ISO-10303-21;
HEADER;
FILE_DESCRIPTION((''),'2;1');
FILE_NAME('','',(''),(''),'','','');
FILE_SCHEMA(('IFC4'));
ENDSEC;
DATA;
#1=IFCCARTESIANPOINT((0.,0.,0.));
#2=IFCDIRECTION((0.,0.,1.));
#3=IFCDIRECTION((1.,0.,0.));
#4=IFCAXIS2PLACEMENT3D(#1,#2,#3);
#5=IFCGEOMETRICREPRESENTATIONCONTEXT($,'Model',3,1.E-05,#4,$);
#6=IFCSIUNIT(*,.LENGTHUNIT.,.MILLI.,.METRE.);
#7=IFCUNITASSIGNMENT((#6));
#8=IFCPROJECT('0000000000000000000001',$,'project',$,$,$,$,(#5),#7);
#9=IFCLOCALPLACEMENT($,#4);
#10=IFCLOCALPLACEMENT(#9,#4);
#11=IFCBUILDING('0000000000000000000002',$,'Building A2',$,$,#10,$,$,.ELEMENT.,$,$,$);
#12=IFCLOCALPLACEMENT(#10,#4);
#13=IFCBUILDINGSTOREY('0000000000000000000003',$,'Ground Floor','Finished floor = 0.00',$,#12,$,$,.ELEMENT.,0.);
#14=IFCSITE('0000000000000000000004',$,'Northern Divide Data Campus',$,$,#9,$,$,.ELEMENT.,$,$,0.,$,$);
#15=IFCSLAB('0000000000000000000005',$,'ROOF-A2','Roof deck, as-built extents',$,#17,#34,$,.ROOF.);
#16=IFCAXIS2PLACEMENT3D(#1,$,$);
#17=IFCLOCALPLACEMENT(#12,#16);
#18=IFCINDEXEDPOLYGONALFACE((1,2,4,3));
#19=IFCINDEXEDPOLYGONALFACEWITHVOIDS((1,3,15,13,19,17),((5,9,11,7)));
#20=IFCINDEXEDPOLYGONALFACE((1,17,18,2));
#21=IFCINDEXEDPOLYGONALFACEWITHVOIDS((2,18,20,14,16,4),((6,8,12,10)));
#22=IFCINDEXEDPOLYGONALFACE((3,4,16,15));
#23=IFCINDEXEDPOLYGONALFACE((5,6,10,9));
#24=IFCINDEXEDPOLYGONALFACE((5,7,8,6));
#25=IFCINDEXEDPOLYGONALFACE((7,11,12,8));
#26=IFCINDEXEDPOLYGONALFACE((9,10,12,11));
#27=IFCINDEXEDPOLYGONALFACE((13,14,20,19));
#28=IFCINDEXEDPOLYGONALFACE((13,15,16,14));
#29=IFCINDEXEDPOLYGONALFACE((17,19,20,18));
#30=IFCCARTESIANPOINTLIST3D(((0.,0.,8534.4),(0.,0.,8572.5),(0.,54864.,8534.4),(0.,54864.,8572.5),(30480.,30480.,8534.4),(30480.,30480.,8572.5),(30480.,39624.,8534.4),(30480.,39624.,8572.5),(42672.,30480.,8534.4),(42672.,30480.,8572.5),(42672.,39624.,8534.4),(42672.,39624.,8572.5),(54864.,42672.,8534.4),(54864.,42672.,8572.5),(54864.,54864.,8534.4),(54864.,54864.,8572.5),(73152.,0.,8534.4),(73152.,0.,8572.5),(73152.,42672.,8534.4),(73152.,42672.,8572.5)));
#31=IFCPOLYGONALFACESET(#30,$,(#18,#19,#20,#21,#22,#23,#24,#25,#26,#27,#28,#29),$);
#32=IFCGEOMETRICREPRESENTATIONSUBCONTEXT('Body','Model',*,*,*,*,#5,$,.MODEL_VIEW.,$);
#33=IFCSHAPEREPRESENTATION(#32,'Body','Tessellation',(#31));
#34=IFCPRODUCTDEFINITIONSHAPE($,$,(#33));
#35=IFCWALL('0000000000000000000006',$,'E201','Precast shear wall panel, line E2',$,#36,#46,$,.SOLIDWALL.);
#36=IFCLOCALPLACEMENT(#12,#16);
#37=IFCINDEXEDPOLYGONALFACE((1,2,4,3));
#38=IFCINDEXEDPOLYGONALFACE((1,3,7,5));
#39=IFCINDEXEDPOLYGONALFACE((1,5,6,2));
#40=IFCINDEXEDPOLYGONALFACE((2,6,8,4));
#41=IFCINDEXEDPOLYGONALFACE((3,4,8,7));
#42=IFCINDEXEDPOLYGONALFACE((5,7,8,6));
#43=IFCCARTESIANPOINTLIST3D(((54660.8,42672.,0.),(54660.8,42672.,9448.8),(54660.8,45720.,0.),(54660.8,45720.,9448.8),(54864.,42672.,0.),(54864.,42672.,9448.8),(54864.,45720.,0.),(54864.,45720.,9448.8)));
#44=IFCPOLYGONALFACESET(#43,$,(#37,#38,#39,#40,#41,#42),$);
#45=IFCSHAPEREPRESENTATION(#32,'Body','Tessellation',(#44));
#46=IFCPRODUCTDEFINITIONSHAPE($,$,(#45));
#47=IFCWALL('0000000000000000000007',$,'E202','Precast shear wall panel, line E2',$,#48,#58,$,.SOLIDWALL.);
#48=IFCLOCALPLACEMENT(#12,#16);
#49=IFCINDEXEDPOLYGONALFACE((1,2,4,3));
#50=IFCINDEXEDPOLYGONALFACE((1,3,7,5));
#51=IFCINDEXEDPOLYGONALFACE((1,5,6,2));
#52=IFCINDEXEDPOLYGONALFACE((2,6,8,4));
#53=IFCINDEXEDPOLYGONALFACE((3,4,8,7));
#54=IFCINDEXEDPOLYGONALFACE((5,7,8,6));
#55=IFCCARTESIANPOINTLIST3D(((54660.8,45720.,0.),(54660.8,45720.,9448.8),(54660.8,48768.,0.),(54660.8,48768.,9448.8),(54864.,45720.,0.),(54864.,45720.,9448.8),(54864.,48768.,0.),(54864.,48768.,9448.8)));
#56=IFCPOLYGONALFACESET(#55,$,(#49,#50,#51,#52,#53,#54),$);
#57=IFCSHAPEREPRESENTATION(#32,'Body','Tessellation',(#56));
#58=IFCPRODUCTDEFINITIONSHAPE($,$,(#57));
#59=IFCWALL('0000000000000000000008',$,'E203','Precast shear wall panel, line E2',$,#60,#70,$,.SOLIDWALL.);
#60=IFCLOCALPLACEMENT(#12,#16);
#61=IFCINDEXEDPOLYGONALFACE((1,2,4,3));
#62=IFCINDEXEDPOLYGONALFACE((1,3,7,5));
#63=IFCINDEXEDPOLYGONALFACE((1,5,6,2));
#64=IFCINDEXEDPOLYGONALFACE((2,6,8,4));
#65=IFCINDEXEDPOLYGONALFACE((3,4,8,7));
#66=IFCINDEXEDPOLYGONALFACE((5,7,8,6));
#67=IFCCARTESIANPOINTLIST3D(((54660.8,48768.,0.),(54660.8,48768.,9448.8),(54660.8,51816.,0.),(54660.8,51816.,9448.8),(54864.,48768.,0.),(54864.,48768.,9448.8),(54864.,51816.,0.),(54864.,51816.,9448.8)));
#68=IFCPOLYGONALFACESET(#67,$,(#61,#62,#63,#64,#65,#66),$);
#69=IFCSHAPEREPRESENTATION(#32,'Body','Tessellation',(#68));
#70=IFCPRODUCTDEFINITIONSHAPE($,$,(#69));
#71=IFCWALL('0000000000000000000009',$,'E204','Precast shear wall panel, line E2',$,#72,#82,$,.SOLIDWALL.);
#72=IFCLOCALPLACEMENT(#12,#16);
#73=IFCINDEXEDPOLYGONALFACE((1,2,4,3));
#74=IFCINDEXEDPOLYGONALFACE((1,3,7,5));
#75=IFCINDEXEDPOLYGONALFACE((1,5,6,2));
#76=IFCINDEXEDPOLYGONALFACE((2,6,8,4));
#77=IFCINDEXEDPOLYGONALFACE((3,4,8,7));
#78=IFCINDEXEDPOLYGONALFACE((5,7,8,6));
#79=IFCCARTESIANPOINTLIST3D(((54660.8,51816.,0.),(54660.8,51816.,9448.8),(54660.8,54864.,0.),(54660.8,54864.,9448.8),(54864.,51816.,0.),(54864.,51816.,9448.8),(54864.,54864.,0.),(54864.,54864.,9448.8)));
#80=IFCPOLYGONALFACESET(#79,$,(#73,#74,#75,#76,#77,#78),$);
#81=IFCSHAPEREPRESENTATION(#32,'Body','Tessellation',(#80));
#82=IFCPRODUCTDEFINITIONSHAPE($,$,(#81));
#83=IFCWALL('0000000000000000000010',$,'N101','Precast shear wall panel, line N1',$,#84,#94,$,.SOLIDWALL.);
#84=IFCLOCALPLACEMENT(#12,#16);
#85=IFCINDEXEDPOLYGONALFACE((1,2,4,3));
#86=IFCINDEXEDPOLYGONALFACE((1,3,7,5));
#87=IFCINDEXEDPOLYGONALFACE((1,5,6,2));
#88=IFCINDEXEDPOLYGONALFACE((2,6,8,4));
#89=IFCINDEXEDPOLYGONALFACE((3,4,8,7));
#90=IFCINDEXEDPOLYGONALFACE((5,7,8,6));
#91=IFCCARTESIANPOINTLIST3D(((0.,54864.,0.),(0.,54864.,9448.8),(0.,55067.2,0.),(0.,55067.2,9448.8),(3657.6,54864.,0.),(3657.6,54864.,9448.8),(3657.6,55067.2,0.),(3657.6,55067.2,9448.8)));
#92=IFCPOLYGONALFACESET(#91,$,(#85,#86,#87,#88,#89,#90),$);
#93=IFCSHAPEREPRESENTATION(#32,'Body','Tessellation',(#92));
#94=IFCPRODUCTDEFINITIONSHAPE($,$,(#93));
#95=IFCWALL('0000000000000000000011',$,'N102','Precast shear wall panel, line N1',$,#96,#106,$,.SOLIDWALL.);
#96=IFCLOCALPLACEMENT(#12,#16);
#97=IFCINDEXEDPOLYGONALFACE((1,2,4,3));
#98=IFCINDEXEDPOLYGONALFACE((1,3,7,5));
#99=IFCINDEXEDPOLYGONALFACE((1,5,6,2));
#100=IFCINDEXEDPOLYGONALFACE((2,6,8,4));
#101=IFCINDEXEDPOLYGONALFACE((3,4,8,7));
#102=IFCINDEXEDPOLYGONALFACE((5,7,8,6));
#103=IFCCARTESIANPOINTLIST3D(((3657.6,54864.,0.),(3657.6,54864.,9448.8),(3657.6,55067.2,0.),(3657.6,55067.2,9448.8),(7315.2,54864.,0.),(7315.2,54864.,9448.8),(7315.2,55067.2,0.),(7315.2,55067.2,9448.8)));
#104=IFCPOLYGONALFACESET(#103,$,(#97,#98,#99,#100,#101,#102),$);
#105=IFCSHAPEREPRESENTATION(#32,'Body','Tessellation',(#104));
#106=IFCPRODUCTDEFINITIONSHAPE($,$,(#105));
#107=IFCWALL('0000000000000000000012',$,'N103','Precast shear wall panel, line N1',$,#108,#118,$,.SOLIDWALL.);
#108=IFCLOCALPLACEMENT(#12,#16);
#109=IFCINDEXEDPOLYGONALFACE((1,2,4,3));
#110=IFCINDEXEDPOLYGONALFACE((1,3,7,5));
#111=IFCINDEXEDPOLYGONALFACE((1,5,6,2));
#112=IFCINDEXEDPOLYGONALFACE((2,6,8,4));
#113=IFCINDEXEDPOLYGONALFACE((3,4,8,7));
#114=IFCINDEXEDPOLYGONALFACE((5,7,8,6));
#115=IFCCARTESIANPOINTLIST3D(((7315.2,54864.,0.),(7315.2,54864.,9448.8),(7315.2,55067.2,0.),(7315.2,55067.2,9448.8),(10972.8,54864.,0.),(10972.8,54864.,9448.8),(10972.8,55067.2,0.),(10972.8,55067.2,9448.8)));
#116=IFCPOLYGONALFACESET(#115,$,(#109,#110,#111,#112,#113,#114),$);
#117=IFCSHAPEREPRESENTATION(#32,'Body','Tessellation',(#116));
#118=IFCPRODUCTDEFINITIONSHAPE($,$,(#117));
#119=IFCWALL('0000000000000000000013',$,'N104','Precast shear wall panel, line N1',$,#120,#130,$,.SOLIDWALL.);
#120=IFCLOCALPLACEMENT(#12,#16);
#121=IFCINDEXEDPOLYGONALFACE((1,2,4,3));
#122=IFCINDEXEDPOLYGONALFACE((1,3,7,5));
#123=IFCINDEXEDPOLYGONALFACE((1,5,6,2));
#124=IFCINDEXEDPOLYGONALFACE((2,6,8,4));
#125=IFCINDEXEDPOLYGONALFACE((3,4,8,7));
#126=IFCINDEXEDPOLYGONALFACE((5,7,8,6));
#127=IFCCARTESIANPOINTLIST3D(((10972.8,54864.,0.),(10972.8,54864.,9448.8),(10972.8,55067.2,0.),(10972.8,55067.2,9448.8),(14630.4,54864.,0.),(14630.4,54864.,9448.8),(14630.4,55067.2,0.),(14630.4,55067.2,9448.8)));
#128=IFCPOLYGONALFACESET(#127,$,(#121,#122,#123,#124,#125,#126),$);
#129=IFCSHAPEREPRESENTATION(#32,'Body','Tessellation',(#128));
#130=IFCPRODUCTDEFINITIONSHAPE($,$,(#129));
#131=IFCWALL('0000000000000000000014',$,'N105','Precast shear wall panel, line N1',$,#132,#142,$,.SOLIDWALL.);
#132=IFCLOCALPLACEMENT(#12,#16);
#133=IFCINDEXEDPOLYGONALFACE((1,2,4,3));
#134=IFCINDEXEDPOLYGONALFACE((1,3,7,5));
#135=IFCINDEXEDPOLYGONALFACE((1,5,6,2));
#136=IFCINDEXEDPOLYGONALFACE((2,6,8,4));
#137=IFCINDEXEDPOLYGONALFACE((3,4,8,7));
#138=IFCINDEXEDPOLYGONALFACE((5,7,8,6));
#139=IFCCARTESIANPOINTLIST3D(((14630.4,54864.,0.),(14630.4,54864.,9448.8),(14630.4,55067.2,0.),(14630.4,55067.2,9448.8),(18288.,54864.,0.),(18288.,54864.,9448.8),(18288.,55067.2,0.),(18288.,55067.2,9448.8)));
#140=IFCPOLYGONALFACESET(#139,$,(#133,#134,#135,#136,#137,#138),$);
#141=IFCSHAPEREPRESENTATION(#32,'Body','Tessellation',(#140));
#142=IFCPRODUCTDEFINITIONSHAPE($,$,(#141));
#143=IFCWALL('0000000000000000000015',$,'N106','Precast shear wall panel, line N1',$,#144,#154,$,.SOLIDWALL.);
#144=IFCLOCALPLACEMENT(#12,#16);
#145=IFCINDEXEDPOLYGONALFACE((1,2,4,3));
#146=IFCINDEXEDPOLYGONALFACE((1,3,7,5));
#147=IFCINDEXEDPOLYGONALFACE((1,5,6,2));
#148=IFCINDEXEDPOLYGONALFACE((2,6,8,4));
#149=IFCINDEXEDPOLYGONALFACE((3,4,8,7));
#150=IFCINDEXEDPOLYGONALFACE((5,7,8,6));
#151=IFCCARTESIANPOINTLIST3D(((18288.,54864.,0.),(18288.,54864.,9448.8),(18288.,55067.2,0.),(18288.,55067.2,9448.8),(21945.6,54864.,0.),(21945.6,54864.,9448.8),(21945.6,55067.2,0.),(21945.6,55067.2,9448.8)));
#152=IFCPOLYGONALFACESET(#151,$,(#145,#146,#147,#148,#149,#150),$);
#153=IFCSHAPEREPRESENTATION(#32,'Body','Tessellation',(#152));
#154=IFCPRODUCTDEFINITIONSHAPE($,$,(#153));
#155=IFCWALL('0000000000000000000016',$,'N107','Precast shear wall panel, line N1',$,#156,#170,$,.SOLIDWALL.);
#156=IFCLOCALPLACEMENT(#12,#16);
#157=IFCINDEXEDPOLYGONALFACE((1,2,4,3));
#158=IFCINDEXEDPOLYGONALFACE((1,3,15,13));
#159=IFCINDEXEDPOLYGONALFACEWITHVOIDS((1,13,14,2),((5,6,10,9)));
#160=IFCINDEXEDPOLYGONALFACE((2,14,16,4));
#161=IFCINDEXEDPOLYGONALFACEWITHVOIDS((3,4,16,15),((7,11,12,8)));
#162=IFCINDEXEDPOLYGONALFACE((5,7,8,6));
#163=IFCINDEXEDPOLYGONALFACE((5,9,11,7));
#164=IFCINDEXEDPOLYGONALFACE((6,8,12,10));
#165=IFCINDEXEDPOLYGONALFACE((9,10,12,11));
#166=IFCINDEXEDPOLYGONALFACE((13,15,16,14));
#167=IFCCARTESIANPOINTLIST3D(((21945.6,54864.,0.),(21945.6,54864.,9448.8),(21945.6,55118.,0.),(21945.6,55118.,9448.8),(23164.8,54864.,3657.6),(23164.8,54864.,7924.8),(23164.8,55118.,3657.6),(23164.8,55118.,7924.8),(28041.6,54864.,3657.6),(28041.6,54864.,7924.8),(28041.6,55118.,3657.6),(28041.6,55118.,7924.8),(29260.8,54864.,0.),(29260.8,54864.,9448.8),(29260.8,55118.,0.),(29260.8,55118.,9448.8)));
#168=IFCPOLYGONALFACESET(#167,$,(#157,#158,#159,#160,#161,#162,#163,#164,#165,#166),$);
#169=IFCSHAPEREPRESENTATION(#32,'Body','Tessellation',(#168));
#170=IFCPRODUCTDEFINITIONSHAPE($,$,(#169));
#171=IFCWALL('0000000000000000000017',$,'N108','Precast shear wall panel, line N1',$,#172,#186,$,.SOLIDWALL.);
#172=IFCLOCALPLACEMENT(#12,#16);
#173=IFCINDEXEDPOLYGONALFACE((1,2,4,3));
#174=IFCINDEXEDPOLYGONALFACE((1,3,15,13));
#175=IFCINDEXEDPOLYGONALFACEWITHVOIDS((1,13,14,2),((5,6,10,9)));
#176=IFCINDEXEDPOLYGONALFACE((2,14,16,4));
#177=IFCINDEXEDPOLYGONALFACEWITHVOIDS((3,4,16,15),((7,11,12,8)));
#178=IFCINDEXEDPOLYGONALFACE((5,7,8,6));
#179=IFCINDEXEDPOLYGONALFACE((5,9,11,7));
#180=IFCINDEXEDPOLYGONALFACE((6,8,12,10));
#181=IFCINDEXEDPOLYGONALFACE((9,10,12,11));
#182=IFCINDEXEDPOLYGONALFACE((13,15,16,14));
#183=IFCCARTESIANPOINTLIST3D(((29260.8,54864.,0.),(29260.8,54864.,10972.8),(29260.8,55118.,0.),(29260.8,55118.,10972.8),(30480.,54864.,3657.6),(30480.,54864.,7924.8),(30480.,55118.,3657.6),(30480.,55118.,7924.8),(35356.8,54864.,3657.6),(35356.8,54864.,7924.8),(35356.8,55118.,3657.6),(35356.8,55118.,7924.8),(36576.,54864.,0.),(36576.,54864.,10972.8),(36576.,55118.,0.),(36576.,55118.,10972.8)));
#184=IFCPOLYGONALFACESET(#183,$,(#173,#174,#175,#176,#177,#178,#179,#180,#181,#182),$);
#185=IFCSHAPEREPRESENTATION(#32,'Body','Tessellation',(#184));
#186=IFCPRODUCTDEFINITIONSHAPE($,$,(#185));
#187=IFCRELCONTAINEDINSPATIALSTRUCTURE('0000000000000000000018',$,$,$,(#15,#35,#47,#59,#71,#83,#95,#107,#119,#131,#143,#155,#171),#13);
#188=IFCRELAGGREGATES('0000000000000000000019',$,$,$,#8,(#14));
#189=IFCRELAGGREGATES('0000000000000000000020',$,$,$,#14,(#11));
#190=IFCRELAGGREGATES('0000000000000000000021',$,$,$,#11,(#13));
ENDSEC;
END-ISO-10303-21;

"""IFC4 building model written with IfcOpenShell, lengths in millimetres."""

from ifc_helpers import new_model, si_unit, frame, origin, origin_with_axes, place, context, subcontext, project, spatial, polyline, outline, extrude, element, save


model = new_model("IFC4")

# Units and contexts
model_context = context("Model", 3, precision=1e-05, world=origin_with_axes())
body_context = subcontext(model_context, "Body", "Model", "MODEL_VIEW")
ifc_project = project(units=[si_unit("LENGTHUNIT", "METRE", prefix="MILLI")], contexts=[model_context])

# Site, building, storey
site_placement = place(None, origin_with_axes())
site = spatial("IfcSite", under=ifc_project, at=site_placement, Name="Northern Divide Data Campus", CompositionType="ELEMENT", RefElevation=0.0)
building_placement = place(site_placement, origin_with_axes())
building = spatial("IfcBuilding", under=site, at=building_placement, Name="Building A2", CompositionType="ELEMENT")
storey_placement = place(building_placement, origin_with_axes())
storey = spatial("IfcBuildingStorey", under=building, at=storey_placement, Name="Ground Floor", Description="Finished floor = 0.00", CompositionType="ELEMENT", Elevation=0.0)

# Slab
slab_placement = place(storey_placement, frame((0.0, 0.0, 8534.4), z_axis=(0.0, 0.0, 1.0), x_axis=(1.0, 0.0, 0.0)))
element("IfcSlab", 1, at=slab_placement, inside=storey, Name="ROOF-A2", Description="Roof deck, as-built extents", PredefinedType="ROOF", context=body_context, shape_type="SweptSolid", body=[
    extrude(outline(polyline([(0.0, 0.0), (73152.0, 0.0), (73152.0, 42672.0), (54864.0, 42672.0), (54864.0, 54864.0), (0.0, 54864.0), (0.0, 0.0)]), holes=[polyline([(30480.0, 30480.0), (42672.0, 30480.0), (42672.0, 39624.0), (30480.0, 39624.0), (30480.0, 30480.0)])]), origin(), (0.0, 0.0, 1.0), 38.1),
])

# Walls
wall_1_placement = place(storey_placement, origin_with_axes())
element("IfcWall", 2, at=wall_1_placement, inside=storey, Name="E201", Description="Precast shear wall panel, line E2", PredefinedType="SOLIDWALL", context=body_context, shape_type="SweptSolid", body=[
    extrude(outline(polyline([(54660.8, 42672.0), (54864.0, 42672.0), (54864.0, 45720.0), (54660.8, 45720.0), (54660.8, 42672.0)])), origin(), (0.0, 0.0, 1.0), 9448.8),
])
wall_2_placement = place(storey_placement, origin_with_axes())
element("IfcWall", 3, at=wall_2_placement, inside=storey, Name="E202", Description="Precast shear wall panel, line E2", PredefinedType="SOLIDWALL", context=body_context, shape_type="SweptSolid", body=[
    extrude(outline(polyline([(54660.8, 45720.0), (54864.0, 45720.0), (54864.0, 48768.0), (54660.8, 48768.0), (54660.8, 45720.0)])), origin(), (0.0, 0.0, 1.0), 9448.8),
])
wall_3_placement = place(storey_placement, origin_with_axes())
element("IfcWall", 4, at=wall_3_placement, inside=storey, Name="E203", Description="Precast shear wall panel, line E2", PredefinedType="SOLIDWALL", context=body_context, shape_type="SweptSolid", body=[
    extrude(outline(polyline([(54660.8, 48768.0), (54864.0, 48768.0), (54864.0, 51816.0), (54660.8, 51816.0), (54660.8, 48768.0)])), origin(), (0.0, 0.0, 1.0), 9448.8),
])
wall_4_placement = place(storey_placement, origin_with_axes())
element("IfcWall", 5, at=wall_4_placement, inside=storey, Name="E204", Description="Precast shear wall panel, line E2", PredefinedType="SOLIDWALL", context=body_context, shape_type="SweptSolid", body=[
    extrude(outline(polyline([(54660.8, 51816.0), (54864.0, 51816.0), (54864.0, 54864.0), (54660.8, 54864.0), (54660.8, 51816.0)])), origin(), (0.0, 0.0, 1.0), 9448.8),
])
wall_5_placement = place(storey_placement, origin_with_axes())
element("IfcWall", 6, at=wall_5_placement, inside=storey, Name="N101", Description="Precast shear wall panel, line N1", PredefinedType="SOLIDWALL", context=body_context, shape_type="SweptSolid", body=[
    extrude(outline(polyline([(0.0, 54864.0), (3657.6, 54864.0), (3657.6, 55067.2), (0.0, 55067.2), (0.0, 54864.0)])), origin(), (0.0, 0.0, 1.0), 9448.8),
])
wall_6_placement = place(storey_placement, origin_with_axes())
element("IfcWall", 7, at=wall_6_placement, inside=storey, Name="N102", Description="Precast shear wall panel, line N1", PredefinedType="SOLIDWALL", context=body_context, shape_type="SweptSolid", body=[
    extrude(outline(polyline([(3657.6, 54864.0), (7315.2, 54864.0), (7315.2, 55067.2), (3657.6, 55067.2), (3657.6, 54864.0)])), origin(), (0.0, 0.0, 1.0), 9448.8),
])
wall_7_placement = place(storey_placement, origin_with_axes())
element("IfcWall", 8, at=wall_7_placement, inside=storey, Name="N103", Description="Precast shear wall panel, line N1", PredefinedType="SOLIDWALL", context=body_context, shape_type="SweptSolid", body=[
    extrude(outline(polyline([(7315.2, 54864.0), (10972.8, 54864.0), (10972.8, 55067.2), (7315.2, 55067.2), (7315.2, 54864.0)])), origin(), (0.0, 0.0, 1.0), 9448.8),
])
wall_8_placement = place(storey_placement, origin_with_axes())
element("IfcWall", 9, at=wall_8_placement, inside=storey, Name="N104", Description="Precast shear wall panel, line N1", PredefinedType="SOLIDWALL", context=body_context, shape_type="SweptSolid", body=[
    extrude(outline(polyline([(10972.8, 54864.0), (14630.4, 54864.0), (14630.4, 55067.2), (10972.8, 55067.2), (10972.8, 54864.0)])), origin(), (0.0, 0.0, 1.0), 9448.8),
])
wall_9_placement = place(storey_placement, origin_with_axes())
element("IfcWall", 10, at=wall_9_placement, inside=storey, Name="N105", Description="Precast shear wall panel, line N1", PredefinedType="SOLIDWALL", context=body_context, shape_type="SweptSolid", body=[
    extrude(outline(polyline([(14630.4, 54864.0), (18288.0, 54864.0), (18288.0, 55067.2), (14630.4, 55067.2), (14630.4, 54864.0)])), origin(), (0.0, 0.0, 1.0), 9448.8),
])
wall_10_placement = place(storey_placement, origin_with_axes())
element("IfcWall", 11, at=wall_10_placement, inside=storey, Name="N106", Description="Precast shear wall panel, line N1", PredefinedType="SOLIDWALL", context=body_context, shape_type="SweptSolid", body=[
    extrude(outline(polyline([(18288.0, 54864.0), (21945.6, 54864.0), (21945.6, 55067.2), (18288.0, 55067.2), (18288.0, 54864.0)])), origin(), (0.0, 0.0, 1.0), 9448.8),
])

# Walls, openings
wall_11_placement = place(storey_placement, origin_with_axes())
wall_11 = element("IfcWall", 12, at=wall_11_placement, inside=storey, Name="N107", Description="Precast shear wall panel, line N1", PredefinedType="SOLIDWALL", context=body_context, shape_type="SweptSolid", body=[
    extrude(outline(polyline([(21945.6, 54864.0), (29260.8, 54864.0), (29260.8, 55118.0), (21945.6, 55118.0), (21945.6, 54864.0)])), origin(), (0.0, 0.0, 1.0), 9448.8),
])
opening_1_placement = place(storey_placement, origin_with_axes())
element("IfcOpeningElement", 13, at=opening_1_placement, cuts=wall_11, PredefinedType="OPENING", context=body_context, shape_type="SweptSolid", body=[
    extrude(outline(polyline([(23164.8, 54864.0), (28041.6, 54864.0), (28041.6, 55118.0), (23164.8, 55118.0), (23164.8, 54864.0)])), frame((0.0, 0.0, 3657.6), z_axis=(0.0, 0.0, 1.0), x_axis=(1.0, 0.0, 0.0)), (0.0, 0.0, 1.0), 4267.2),
])
wall_12_placement = place(storey_placement, origin_with_axes())
wall_12 = element("IfcWall", 14, at=wall_12_placement, inside=storey, Name="N108", Description="Precast shear wall panel, line N1", PredefinedType="SOLIDWALL", context=body_context, shape_type="SweptSolid", body=[
    extrude(outline(polyline([(29260.8, 54864.0), (36576.0, 54864.0), (36576.0, 55118.0), (29260.8, 55118.0), (29260.8, 54864.0)])), origin(), (0.0, 0.0, 1.0), 10972.8),
])
opening_2_placement = place(storey_placement, origin_with_axes())
element("IfcOpeningElement", 15, at=opening_2_placement, cuts=wall_12, PredefinedType="OPENING", context=body_context, shape_type="SweptSolid", body=[
    extrude(outline(polyline([(30480.0, 54864.0), (35356.8, 54864.0), (35356.8, 55118.0), (30480.0, 55118.0), (30480.0, 54864.0)])), frame((0.0, 0.0, 3657.6), z_axis=(0.0, 0.0, 1.0), x_axis=(1.0, 0.0, 0.0)), (0.0, 0.0, 1.0), 4267.2),
])

save(model, "model.ifc")
